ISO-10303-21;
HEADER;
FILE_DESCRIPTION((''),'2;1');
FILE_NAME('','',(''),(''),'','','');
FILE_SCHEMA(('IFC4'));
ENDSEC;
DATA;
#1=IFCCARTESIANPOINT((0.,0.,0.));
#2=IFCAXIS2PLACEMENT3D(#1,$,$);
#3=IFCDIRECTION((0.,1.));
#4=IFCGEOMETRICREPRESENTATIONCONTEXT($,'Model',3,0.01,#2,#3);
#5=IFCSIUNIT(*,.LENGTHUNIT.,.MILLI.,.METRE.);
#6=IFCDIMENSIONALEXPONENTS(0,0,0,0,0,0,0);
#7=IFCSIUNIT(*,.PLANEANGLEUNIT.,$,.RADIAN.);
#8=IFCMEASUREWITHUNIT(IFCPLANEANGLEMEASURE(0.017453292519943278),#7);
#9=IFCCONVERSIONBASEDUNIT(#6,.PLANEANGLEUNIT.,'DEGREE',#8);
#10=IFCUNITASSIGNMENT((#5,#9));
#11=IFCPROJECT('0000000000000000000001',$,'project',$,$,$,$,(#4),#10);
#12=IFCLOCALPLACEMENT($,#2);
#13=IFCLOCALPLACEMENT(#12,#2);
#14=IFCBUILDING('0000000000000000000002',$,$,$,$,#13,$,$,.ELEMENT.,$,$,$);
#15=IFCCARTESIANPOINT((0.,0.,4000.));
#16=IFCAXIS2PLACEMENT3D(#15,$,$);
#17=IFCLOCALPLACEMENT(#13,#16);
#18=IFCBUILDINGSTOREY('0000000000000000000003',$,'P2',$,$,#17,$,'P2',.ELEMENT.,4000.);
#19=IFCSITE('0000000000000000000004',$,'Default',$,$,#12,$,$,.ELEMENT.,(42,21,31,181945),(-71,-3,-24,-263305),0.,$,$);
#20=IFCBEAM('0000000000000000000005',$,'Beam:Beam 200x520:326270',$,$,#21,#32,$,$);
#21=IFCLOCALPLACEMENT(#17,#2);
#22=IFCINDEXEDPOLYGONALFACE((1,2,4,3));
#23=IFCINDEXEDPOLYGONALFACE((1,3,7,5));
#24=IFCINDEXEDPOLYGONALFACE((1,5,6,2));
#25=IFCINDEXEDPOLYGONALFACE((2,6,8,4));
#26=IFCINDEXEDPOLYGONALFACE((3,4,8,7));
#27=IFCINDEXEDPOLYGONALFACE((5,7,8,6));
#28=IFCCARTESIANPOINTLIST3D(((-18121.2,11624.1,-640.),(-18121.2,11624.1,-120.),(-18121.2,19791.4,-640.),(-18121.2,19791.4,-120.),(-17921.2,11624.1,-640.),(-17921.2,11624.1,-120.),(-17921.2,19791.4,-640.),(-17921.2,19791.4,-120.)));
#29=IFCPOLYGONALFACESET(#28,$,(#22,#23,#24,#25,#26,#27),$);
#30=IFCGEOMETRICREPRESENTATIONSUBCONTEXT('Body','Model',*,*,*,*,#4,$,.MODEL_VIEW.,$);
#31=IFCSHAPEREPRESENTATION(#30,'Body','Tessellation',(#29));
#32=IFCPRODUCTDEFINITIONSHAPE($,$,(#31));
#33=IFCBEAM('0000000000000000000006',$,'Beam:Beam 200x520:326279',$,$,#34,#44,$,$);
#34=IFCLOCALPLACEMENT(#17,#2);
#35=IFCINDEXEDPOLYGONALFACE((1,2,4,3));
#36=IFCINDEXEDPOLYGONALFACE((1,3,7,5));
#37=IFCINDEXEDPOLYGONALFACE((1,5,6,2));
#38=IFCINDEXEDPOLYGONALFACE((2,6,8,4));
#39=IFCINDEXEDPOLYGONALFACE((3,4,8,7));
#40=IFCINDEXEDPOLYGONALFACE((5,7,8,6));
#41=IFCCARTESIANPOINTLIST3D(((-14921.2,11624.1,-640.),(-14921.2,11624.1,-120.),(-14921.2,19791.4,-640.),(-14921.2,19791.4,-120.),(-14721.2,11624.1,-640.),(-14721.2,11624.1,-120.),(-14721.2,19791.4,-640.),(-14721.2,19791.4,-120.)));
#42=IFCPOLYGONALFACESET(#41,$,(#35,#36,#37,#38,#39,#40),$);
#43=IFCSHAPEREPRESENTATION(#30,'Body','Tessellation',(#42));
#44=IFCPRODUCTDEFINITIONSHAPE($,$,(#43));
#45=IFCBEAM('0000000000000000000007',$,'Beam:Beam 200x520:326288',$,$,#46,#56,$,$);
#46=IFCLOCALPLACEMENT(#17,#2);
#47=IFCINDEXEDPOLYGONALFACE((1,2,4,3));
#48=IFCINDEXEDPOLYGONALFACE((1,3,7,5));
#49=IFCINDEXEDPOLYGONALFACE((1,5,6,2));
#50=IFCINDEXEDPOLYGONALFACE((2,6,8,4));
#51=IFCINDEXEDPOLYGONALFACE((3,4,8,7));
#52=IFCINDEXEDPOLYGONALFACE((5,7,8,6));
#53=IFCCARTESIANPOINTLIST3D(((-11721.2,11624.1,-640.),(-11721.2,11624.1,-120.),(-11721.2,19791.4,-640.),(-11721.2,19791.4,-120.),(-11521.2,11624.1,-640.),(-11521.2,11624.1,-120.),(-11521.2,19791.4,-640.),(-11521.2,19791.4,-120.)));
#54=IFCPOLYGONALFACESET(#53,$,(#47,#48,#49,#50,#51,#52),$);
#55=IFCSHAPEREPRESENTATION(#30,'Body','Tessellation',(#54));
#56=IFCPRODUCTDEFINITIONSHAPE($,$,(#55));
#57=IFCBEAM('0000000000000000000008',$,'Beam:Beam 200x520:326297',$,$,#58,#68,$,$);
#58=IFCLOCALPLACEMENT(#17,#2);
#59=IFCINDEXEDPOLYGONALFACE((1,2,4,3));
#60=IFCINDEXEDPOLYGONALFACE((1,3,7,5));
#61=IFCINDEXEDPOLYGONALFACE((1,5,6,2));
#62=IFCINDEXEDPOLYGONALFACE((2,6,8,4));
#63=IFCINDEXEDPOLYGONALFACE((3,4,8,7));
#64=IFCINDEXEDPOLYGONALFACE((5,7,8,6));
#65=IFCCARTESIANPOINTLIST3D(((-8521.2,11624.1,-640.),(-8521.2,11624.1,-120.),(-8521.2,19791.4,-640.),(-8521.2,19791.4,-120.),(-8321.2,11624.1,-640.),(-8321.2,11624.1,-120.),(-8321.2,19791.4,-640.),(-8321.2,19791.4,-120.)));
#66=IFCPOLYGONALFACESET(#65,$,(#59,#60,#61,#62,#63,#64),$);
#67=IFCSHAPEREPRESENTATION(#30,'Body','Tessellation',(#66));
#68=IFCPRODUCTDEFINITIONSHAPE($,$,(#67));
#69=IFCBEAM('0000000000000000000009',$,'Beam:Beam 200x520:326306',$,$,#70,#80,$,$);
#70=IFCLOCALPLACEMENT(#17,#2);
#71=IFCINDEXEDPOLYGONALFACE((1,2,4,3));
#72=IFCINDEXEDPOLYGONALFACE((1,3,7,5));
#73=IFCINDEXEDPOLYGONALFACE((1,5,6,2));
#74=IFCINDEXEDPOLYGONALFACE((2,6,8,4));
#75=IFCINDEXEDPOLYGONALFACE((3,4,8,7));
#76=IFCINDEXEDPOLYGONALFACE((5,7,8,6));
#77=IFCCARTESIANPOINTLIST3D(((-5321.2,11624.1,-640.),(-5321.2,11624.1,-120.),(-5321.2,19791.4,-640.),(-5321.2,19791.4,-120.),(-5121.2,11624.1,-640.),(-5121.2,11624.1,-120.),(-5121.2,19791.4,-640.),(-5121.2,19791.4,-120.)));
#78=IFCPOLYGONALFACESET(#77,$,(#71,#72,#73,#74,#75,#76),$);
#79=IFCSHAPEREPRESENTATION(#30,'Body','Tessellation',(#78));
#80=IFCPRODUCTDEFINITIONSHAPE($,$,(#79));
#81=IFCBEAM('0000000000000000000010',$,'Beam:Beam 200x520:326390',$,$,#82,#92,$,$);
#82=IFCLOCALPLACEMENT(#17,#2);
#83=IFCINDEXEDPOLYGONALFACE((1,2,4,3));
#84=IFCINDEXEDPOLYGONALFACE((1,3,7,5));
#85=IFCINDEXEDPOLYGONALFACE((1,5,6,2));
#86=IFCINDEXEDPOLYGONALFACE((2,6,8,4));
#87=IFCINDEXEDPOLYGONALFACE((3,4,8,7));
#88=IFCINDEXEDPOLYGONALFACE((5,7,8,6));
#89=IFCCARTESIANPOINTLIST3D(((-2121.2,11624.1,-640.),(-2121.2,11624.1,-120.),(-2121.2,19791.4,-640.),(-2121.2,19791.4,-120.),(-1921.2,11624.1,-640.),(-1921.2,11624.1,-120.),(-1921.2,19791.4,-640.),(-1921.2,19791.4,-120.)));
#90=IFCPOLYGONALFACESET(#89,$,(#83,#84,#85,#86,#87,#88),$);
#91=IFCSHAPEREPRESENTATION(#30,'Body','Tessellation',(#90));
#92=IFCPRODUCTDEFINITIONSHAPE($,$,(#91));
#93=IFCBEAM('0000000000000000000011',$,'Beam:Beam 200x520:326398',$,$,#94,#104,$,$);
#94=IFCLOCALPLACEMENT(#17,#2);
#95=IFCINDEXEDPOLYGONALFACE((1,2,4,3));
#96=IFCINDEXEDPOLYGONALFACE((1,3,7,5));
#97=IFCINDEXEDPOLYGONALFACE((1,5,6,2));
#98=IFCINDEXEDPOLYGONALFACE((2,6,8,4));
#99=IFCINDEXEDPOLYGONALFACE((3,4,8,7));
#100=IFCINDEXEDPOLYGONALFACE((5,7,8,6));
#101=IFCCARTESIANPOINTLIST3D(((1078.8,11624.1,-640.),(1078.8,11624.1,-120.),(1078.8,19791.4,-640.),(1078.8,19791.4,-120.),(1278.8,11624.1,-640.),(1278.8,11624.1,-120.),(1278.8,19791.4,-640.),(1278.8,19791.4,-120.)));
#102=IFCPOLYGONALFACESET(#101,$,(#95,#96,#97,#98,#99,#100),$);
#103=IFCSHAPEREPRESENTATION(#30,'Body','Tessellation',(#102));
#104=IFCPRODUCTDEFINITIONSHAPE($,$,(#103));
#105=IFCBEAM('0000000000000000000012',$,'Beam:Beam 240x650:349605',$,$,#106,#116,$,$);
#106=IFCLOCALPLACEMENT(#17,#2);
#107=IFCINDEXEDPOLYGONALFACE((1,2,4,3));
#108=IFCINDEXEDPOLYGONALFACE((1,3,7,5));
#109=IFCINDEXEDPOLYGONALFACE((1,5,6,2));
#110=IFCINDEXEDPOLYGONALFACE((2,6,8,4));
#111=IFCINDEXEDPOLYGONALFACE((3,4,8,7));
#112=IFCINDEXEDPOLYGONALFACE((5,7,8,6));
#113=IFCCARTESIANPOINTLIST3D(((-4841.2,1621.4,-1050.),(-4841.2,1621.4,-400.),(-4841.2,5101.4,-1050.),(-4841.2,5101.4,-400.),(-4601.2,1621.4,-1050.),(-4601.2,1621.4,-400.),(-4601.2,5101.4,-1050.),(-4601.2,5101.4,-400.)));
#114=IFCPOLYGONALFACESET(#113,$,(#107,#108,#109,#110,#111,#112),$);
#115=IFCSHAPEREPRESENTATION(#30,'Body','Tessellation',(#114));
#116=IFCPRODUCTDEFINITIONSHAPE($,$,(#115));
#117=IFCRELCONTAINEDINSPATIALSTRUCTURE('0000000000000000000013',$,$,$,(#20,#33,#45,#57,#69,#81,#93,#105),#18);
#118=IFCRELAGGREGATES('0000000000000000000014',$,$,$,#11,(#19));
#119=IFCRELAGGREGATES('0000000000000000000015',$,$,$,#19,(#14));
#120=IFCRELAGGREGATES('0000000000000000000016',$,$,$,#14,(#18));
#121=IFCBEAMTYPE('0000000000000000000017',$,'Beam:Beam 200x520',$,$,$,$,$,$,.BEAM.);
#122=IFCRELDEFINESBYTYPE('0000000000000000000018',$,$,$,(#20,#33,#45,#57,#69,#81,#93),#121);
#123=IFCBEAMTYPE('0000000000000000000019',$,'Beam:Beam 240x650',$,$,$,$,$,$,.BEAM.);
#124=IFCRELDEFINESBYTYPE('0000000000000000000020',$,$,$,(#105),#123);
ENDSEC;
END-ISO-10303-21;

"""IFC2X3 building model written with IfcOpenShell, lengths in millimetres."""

from ifc_helpers import new_model, entity, si_unit, converted_unit, direction, frame, frame_2d, origin, place, context, subcontext, project, spatial, rectangle, extrude, type_object, element, save


model = new_model("IFC2X3")

# Units and contexts
model_context = context("Model", 3, precision=0.01, world=origin(), true_north=direction((0.0, 1.0)))
body_context = subcontext(model_context, "Body", "Model", "MODEL_VIEW")
ifc_project = project(units=[si_unit("LENGTHUNIT", "METRE", prefix="MILLI"), converted_unit("PLANEANGLEUNIT", "DEGREE", entity("IfcPlaneAngleMeasure", 0.017453292519943278), si_unit("PLANEANGLEUNIT", "RADIAN"), dimensions=[0, 0, 0, 0, 0, 0, 0])], contexts=[model_context])

# Site, building, storey
site_placement = place(None, origin())
site = spatial("IfcSite", under=ifc_project, at=site_placement, Name="Default", CompositionType="ELEMENT", RefLatitude=(42, 21, 31, 181945), RefLongitude=(-71, -3, -24, -263305), RefElevation=0.0)
building_placement = place(site_placement, origin())
building = spatial("IfcBuilding", under=site, at=building_placement, CompositionType="ELEMENT")
storey_placement = place(building_placement, frame((0.0, 0.0, 4000.0)))
storey = spatial("IfcBuildingStorey", under=building, at=storey_placement, Name="P2", LongName="P2", CompositionType="ELEMENT", Elevation=4000.0)

# Beams
beam_type_1 = type_object("IfcBeamType", Name="Beam:Beam 200x520", PredefinedType="BEAM")
beam_1_placement = place(storey_placement, frame((-18046.2, 19791.4, -120.0), z_axis=(0.0, 0.0, 1.0), x_axis=(0.0, -1.0, 0.0)))
element("IfcBeam", 1, at=beam_1_placement, inside=storey, type_object=beam_type_1, Name="Beam:Beam 200x520:326270", context=body_context, shape_type="SweptSolid", body=[
    extrude(rectangle(XDim=520.0, YDim=200.0, at=frame_2d((0.0, 0.0), x_axis=(1.0, 0.0))), frame((0.0, 25.0, -260.0), z_axis=(1.0, 0.0, 0.0), x_axis=(0.0, 0.0, -1.0)), (0.0, 0.0, 1.0), 8167.3),
])
beam_2_placement = place(storey_placement, frame((-14846.2, 19791.4, -120.0), z_axis=(0.0, 0.0, 1.0), x_axis=(0.0, -1.0, 0.0)))
element("IfcBeam", 2, at=beam_2_placement, inside=storey, type_object=beam_type_1, Name="Beam:Beam 200x520:326279", context=body_context, shape_type="SweptSolid", body=[
    extrude(rectangle(XDim=520.0, YDim=200.0, at=frame_2d((0.0, 0.0), x_axis=(1.0, 0.0))), frame((0.0, 25.0, -260.0), z_axis=(1.0, 0.0, 0.0), x_axis=(0.0, 0.0, -1.0)), (0.0, 0.0, 1.0), 8167.3),
])
beam_3_placement = place(storey_placement, frame((-11646.2, 19791.4, -120.0), z_axis=(0.0, 0.0, 1.0), x_axis=(0.0, -1.0, 0.0)))
element("IfcBeam", 3, at=beam_3_placement, inside=storey, type_object=beam_type_1, Name="Beam:Beam 200x520:326288", context=body_context, shape_type="SweptSolid", body=[
    extrude(rectangle(XDim=520.0, YDim=200.0, at=frame_2d((0.0, 0.0), x_axis=(1.0, 0.0))), frame((0.0, 25.0, -260.0), z_axis=(1.0, 0.0, 0.0), x_axis=(0.0, 0.0, -1.0)), (0.0, 0.0, 1.0), 8167.3),
])
beam_4_placement = place(storey_placement, frame((-8446.2, 19791.4, -120.0), z_axis=(0.0, 0.0, 1.0), x_axis=(0.0, -1.0, 0.0)))
element("IfcBeam", 4, at=beam_4_placement, inside=storey, type_object=beam_type_1, Name="Beam:Beam 200x520:326297", context=body_context, shape_type="SweptSolid", body=[
    extrude(rectangle(XDim=520.0, YDim=200.0, at=frame_2d((0.0, 0.0), x_axis=(1.0, 0.0))), frame((0.0, 25.0, -260.0), z_axis=(1.0, 0.0, 0.0), x_axis=(0.0, 0.0, -1.0)), (0.0, 0.0, 1.0), 8167.3),
])
beam_5_placement = place(storey_placement, frame((-5246.2, 19791.4, -120.0), z_axis=(0.0, 0.0, 1.0), x_axis=(0.0, -1.0, 0.0)))
element("IfcBeam", 5, at=beam_5_placement, inside=storey, type_object=beam_type_1, Name="Beam:Beam 200x520:326306", context=body_context, shape_type="SweptSolid", body=[
    extrude(rectangle(XDim=520.0, YDim=200.0, at=frame_2d((0.0, 0.0), x_axis=(1.0, 0.0))), frame((0.0, 25.0, -260.0), z_axis=(1.0, 0.0, 0.0), x_axis=(0.0, 0.0, -1.0)), (0.0, 0.0, 1.0), 8167.3),
])
beam_6_placement = place(storey_placement, frame((-2046.2, 19791.4, -120.0), z_axis=(0.0, 0.0, 1.0), x_axis=(0.0, -1.0, 0.0)))
element("IfcBeam", 6, at=beam_6_placement, inside=storey, type_object=beam_type_1, Name="Beam:Beam 200x520:326390", context=body_context, shape_type="SweptSolid", body=[
    extrude(rectangle(XDim=520.0, YDim=200.0, at=frame_2d((0.0, 0.0), x_axis=(1.0, 0.0))), frame((0.0, 25.0, -260.0), z_axis=(1.0, 0.0, 0.0), x_axis=(0.0, 0.0, -1.0)), (0.0, 0.0, 1.0), 8167.3),
])
beam_7_placement = place(storey_placement, frame((1153.8, 19791.4, -120.0), z_axis=(0.0, 0.0, 1.0), x_axis=(0.0, -1.0, 0.0)))
element("IfcBeam", 7, at=beam_7_placement, inside=storey, type_object=beam_type_1, Name="Beam:Beam 200x520:326398", context=body_context, shape_type="SweptSolid", body=[
    extrude(rectangle(XDim=520.0, YDim=200.0, at=frame_2d((0.0, 0.0), x_axis=(1.0, 0.0))), frame((0.0, 25.0, -260.0), z_axis=(1.0, 0.0, 0.0), x_axis=(0.0, 0.0, -1.0)), (0.0, 0.0, 1.0), 8167.3),
])
beam_type_2 = type_object("IfcBeamType", Name="Beam:Beam 240x650", PredefinedType="BEAM")
beam_8_placement = place(storey_placement, frame((-4726.2, 5101.4, -400.0), z_axis=(0.0, 0.0, 1.0), x_axis=(0.0, -1.0, 0.0)))
element("IfcBeam", 8, at=beam_8_placement, inside=storey, type_object=beam_type_2, Name="Beam:Beam 240x650:349605", context=body_context, shape_type="SweptSolid", body=[
    extrude(rectangle(XDim=650.0, YDim=240.0, at=frame_2d((0.0, 0.0), x_axis=(1.0, 0.0))), frame((0.0, 5.0, -325.0), z_axis=(1.0, 0.0, 0.0), x_axis=(0.0, 0.0, -1.0)), (0.0, 0.0, 1.0), 3480.0),
])

save(model, "model.ifc")
